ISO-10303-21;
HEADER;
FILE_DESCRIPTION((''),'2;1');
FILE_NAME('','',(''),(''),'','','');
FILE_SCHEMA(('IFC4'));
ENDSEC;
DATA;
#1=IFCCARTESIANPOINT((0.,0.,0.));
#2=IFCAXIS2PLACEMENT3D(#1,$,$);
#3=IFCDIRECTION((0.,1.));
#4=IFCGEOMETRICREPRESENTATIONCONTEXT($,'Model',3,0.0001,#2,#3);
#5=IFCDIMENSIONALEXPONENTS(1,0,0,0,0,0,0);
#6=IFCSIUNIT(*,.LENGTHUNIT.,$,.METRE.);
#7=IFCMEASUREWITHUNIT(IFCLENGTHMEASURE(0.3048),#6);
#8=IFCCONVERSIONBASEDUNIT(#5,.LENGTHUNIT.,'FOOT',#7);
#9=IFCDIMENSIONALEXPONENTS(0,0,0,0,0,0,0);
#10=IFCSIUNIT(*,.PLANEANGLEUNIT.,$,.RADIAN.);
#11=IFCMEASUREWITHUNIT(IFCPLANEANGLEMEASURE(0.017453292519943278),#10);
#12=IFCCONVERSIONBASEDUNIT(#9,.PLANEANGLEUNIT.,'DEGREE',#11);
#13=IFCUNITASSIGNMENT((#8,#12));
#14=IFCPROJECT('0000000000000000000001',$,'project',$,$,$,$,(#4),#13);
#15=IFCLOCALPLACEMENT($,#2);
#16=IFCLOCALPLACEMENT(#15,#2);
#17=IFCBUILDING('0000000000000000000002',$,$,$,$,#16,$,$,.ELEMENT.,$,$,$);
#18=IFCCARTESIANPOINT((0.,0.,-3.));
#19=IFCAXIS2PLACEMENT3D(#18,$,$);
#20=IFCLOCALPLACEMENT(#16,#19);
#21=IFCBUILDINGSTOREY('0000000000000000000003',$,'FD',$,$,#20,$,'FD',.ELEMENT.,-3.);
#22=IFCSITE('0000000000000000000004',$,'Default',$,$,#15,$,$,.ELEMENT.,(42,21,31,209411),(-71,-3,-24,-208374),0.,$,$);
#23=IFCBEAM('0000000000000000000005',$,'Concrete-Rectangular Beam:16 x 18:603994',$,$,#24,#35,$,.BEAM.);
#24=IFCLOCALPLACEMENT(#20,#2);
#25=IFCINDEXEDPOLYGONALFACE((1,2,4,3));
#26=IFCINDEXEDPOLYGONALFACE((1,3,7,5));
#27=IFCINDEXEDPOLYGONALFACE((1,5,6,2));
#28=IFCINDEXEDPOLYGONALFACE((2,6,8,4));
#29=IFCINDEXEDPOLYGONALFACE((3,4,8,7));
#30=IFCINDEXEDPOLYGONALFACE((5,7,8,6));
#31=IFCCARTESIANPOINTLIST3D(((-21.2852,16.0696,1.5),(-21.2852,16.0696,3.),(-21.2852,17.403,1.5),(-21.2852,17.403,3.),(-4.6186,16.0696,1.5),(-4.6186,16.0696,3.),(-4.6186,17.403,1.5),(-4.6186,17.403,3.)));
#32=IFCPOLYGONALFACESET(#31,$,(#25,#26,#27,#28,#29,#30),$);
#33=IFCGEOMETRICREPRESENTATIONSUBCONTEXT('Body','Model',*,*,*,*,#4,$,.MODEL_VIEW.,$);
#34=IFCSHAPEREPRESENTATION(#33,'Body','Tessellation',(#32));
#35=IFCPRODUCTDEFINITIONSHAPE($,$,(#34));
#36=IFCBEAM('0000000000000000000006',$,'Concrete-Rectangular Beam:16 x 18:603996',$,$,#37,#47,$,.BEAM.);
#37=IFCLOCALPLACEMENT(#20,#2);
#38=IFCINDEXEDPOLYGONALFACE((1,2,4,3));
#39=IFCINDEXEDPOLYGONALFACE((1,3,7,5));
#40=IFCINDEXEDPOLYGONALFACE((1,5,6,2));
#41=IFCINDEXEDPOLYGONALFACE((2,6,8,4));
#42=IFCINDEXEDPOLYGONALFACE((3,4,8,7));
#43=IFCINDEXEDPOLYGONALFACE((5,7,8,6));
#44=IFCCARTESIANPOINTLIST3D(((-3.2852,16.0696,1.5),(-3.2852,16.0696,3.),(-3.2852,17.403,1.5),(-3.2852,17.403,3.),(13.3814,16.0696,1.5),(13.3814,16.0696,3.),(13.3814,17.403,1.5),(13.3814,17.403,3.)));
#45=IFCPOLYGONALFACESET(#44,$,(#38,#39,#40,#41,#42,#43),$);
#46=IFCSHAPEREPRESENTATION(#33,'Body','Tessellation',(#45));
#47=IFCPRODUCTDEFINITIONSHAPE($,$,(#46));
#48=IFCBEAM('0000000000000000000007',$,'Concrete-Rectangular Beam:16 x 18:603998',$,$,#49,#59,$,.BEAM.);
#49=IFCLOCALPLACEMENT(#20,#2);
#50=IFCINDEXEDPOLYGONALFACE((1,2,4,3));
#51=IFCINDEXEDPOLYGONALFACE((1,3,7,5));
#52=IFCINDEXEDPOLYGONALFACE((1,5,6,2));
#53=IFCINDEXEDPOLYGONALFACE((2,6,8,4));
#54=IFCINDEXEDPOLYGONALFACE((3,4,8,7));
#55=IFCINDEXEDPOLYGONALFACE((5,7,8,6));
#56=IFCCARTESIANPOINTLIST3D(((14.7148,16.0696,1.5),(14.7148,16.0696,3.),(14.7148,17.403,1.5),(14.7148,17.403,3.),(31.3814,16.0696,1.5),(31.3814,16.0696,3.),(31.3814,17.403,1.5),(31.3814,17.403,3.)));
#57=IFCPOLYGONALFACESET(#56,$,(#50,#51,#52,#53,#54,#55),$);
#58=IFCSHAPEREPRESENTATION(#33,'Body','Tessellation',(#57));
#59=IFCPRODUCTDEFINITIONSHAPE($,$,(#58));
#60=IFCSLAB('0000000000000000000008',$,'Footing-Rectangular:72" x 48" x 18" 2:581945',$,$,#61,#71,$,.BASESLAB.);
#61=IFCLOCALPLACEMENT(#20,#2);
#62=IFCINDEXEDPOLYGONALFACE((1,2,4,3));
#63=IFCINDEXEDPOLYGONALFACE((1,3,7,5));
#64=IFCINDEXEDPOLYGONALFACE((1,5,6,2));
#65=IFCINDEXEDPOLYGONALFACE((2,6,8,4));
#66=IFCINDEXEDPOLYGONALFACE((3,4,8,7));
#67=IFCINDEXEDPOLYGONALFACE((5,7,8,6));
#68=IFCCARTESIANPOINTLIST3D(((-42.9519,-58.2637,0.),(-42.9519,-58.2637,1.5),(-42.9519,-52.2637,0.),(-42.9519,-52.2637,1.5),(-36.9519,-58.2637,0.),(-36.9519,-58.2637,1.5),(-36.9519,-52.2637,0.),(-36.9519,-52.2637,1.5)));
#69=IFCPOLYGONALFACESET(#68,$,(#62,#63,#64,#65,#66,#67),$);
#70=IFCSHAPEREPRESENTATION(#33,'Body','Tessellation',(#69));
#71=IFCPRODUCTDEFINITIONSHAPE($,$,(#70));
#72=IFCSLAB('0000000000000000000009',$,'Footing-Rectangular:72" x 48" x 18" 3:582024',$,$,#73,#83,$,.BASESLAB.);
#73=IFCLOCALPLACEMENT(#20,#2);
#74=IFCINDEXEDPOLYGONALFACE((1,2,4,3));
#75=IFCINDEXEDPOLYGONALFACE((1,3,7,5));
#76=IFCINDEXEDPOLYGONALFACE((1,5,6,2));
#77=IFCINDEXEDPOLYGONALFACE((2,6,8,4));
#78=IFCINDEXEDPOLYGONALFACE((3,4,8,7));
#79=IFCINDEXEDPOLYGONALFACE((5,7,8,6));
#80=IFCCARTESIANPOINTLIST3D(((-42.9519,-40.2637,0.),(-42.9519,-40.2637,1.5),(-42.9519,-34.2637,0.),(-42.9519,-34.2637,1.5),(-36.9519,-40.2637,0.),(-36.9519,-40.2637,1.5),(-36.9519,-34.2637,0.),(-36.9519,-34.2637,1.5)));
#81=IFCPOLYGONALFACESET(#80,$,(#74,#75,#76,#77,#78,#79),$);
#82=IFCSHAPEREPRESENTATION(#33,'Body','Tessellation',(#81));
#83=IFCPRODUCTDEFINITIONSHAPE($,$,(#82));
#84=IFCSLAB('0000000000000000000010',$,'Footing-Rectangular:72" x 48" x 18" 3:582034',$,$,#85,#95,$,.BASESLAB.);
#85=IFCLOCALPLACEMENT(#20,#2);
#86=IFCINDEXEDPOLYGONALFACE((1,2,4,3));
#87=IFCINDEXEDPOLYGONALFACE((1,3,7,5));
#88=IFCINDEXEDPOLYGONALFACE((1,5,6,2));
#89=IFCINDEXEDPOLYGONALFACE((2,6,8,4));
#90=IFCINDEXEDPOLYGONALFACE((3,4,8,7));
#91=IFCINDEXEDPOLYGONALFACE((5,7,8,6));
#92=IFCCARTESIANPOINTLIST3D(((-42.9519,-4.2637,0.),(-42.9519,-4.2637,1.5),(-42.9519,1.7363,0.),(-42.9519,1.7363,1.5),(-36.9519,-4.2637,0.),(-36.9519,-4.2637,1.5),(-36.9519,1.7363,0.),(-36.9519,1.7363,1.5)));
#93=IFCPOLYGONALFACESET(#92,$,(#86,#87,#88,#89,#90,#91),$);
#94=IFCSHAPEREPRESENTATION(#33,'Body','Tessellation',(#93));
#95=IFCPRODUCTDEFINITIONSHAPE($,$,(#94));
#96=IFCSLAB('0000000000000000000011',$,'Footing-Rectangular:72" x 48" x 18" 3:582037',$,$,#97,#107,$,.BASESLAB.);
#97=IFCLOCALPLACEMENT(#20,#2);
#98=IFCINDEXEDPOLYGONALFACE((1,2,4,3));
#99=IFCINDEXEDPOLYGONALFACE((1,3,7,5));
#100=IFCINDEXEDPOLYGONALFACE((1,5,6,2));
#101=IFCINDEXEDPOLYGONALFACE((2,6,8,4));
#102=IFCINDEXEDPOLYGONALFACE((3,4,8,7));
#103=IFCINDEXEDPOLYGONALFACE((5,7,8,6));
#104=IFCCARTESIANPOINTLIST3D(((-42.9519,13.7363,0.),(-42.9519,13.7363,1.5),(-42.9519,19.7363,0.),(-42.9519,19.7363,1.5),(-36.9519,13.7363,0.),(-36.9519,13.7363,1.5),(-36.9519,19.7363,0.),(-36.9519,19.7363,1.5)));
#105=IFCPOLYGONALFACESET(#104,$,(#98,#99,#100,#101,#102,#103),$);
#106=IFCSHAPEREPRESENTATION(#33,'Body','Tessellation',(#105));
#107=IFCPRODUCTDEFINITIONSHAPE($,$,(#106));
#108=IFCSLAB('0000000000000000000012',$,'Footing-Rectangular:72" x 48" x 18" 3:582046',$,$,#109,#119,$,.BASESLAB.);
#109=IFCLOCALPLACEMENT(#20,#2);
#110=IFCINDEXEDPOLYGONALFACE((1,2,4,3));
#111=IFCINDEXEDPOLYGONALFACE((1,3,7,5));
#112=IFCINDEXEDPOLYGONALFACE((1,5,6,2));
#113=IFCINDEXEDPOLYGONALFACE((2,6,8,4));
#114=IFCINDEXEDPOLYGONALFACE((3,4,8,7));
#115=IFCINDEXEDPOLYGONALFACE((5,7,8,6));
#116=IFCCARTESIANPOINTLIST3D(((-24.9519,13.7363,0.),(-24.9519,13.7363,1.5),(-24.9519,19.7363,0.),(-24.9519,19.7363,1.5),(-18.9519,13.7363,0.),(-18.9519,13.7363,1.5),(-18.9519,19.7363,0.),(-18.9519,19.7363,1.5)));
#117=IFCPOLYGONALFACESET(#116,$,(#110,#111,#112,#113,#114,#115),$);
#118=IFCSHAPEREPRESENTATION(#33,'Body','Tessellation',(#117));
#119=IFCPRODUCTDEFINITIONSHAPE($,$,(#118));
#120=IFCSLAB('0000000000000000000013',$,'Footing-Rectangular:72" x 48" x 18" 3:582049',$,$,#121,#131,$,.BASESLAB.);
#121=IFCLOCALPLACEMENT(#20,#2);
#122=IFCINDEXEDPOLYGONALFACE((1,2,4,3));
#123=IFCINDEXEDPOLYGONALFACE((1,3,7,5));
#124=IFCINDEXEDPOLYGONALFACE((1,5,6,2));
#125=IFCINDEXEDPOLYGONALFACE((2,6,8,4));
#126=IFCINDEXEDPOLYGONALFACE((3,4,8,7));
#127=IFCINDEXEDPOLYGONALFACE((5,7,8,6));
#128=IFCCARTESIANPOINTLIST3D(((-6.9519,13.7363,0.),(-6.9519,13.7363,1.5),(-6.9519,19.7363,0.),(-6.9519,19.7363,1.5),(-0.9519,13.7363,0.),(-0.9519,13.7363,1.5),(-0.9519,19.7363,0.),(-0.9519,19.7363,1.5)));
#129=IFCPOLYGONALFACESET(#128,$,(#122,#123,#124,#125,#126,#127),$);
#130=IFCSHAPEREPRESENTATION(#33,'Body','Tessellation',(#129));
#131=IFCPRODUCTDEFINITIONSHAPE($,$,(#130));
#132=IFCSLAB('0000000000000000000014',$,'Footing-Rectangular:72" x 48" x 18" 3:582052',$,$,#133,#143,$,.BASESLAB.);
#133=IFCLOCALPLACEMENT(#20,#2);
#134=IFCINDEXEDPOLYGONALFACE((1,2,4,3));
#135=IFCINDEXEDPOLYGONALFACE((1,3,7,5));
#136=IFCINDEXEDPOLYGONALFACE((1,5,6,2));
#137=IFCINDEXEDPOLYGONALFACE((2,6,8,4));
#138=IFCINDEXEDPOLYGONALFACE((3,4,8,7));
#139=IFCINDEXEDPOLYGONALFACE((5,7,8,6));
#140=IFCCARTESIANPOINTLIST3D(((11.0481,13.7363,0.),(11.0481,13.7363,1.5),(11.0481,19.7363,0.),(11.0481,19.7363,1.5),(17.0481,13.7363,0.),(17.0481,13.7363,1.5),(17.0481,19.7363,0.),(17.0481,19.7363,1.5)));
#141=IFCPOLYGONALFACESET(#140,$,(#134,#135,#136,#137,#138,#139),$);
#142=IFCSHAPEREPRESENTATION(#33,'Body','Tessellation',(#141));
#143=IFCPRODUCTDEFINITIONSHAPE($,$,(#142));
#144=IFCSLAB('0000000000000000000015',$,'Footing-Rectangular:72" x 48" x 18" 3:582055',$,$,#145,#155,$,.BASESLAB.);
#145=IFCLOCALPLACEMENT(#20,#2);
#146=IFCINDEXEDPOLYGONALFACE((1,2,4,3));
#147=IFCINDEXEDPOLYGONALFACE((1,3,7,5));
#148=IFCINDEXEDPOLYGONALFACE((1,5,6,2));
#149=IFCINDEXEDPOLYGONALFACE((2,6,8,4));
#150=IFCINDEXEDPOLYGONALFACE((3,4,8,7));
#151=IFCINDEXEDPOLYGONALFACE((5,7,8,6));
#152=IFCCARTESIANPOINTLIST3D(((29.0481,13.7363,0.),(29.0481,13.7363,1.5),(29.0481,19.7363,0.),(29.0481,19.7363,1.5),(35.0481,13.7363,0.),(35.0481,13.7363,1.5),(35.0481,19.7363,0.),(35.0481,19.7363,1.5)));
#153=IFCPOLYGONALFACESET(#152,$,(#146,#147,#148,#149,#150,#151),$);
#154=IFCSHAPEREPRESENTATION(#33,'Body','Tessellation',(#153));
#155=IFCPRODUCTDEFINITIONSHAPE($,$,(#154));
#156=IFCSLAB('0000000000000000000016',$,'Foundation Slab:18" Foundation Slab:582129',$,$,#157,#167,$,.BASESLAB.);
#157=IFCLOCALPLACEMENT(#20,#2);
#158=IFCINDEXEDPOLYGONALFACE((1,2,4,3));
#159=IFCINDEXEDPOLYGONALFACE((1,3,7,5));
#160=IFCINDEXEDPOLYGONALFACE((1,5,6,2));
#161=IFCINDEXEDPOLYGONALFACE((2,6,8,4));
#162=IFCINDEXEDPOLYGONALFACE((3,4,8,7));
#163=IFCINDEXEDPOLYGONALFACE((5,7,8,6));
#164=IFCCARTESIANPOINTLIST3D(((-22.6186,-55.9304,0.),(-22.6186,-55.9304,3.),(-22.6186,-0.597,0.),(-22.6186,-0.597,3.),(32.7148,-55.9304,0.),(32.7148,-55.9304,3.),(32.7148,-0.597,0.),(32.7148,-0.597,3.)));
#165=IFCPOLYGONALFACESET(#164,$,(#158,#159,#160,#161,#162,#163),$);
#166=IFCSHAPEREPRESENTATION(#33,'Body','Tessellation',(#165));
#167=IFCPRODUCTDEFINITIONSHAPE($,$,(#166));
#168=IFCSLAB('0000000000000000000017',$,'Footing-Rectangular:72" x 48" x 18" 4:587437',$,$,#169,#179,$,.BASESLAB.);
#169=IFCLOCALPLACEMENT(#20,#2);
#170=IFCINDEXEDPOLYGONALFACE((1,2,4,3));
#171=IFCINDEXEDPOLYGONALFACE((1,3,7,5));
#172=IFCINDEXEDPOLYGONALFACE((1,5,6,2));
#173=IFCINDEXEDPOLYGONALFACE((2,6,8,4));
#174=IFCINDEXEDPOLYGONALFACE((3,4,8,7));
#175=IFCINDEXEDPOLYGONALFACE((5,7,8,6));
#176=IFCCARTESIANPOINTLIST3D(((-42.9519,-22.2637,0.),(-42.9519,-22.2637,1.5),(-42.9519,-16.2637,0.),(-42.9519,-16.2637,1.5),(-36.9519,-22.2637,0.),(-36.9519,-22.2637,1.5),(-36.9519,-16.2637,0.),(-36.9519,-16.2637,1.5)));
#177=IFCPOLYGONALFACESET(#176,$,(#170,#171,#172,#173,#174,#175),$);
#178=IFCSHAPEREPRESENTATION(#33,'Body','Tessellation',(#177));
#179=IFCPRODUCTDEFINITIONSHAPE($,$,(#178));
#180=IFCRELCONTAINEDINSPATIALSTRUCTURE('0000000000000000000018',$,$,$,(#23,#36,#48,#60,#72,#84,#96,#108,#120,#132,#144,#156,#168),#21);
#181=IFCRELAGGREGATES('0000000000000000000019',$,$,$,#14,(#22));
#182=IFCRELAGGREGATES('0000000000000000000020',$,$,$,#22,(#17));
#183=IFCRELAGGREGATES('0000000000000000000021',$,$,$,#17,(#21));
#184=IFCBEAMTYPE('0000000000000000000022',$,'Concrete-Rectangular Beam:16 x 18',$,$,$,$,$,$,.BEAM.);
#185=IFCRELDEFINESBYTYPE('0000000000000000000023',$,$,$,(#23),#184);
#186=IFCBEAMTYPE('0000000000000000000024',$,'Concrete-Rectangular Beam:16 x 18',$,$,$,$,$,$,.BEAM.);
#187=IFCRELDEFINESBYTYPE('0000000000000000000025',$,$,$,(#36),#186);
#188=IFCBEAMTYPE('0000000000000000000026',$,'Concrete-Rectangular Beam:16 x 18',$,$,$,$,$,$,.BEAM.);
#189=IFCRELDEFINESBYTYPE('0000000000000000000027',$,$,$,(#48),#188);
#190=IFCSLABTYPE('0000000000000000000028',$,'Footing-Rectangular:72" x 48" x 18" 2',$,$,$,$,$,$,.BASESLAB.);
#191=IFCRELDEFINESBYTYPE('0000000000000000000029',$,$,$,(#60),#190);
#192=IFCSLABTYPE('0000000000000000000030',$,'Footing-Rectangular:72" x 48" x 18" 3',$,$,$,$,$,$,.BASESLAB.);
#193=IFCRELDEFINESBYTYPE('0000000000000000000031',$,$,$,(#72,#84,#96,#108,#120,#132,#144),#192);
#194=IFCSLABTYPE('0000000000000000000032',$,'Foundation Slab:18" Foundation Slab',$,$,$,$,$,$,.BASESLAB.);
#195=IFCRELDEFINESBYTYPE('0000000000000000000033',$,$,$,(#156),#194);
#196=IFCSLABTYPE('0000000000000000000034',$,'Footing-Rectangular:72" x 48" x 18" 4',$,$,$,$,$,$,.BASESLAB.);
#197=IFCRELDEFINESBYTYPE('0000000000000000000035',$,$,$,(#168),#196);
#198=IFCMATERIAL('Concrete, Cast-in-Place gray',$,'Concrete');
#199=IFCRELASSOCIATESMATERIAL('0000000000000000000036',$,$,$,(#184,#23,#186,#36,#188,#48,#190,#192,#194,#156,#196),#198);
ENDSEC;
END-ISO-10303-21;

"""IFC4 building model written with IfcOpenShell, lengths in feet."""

from ifc_helpers import new_model, entity, si_unit, converted_unit, direction, frame, origin, place, context, subcontext, project, spatial, indexed_curve, outline, extrude, source, transform, mapped, material, type_object, type_shapes, element, save


model = new_model("IFC4")

# Units and contexts
model_context = context("Model", 3, precision=0.0001, world=origin(), true_north=direction((0.0, 1.0)))
body_context = subcontext(model_context, "Body", "Model", "MODEL_VIEW")
ifc_project = project(units=[converted_unit("LENGTHUNIT", "FOOT", entity("IfcLengthMeasure", 0.3048), si_unit("LENGTHUNIT", "METRE"), dimensions=[1, 0, 0, 0, 0, 0, 0]), converted_unit("PLANEANGLEUNIT", "DEGREE", entity("IfcPlaneAngleMeasure", 0.017453292519943278), si_unit("PLANEANGLEUNIT", "RADIAN"), dimensions=[0, 0, 0, 0, 0, 0, 0])], contexts=[model_context])

# Site, building, storey
site_placement = place(None, origin())
site = spatial("IfcSite", under=ifc_project, at=site_placement, Name="Default", CompositionType="ELEMENT", RefLatitude=(42, 21, 31, 209411), RefLongitude=(-71, -3, -24, -208374), RefElevation=0.0)
building_placement = place(site_placement, origin())
building = spatial("IfcBuilding", under=site, at=building_placement, CompositionType="ELEMENT")
storey_placement = place(building_placement, frame((0.0, 0.0, -3.0)))
storey = spatial("IfcBuildingStorey", under=building, at=storey_placement, Name="FD", LongName="FD", CompositionType="ELEMENT", Elevation=-3.0)

# Shared definitions
ifc_material = material(Name="Concrete, Cast-in-Place gray", Category="Concrete")

# Beams
beam_type_1 = type_object("IfcBeamType", Name="Concrete-Rectangular Beam:16 x 18", PredefinedType="BEAM", material=ifc_material)
shared_shape_1 = source(origin(), body_context, "Body", "SweptSolid", [
    extrude(outline(indexed_curve([(-0.75, -0.6667), (0.75, -0.6667), (0.75, 0.6667), (-0.75, 0.6667), (-0.75, -0.6667)], self_intersect=False)), frame((-21.2852, 16.7363, -0.75), z_axis=(1.0, 0.0, 0.0), x_axis=(0.0, 0.0, -1.0)), (0.0, 0.0, 1.0), 16.6667),
])
type_shapes(beam_type_1, [shared_shape_1])
beam_1_placement = place(storey_placement, frame((0.0, 0.0, 3.0)))
element("IfcBeam", 1, at=beam_1_placement, inside=storey, type_object=beam_type_1, material=ifc_material, Name="Concrete-Rectangular Beam:16 x 18:603994", PredefinedType="BEAM", context=body_context, shape_type="MappedRepresentation", body=[
    mapped(shared_shape_1, transform((0.0, 0.0, 0.0), scale=1.0)),
])
beam_type_2 = type_object("IfcBeamType", Name="Concrete-Rectangular Beam:16 x 18", PredefinedType="BEAM", material=ifc_material)
shared_shape_2 = source(origin(), body_context, "Body", "SweptSolid", [
    extrude(outline(indexed_curve([(-0.75, -0.6667), (0.75, -0.6667), (0.75, 0.6667), (-0.75, 0.6667), (-0.75, -0.6667)], self_intersect=False)), frame((-3.2852, 16.7363, -0.75), z_axis=(1.0, 0.0, 0.0), x_axis=(0.0, 0.0, -1.0)), (0.0, 0.0, 1.0), 16.6667),
])
type_shapes(beam_type_2, [shared_shape_2])
beam_2_placement = place(storey_placement, frame((0.0, 0.0, 3.0)))
element("IfcBeam", 2, at=beam_2_placement, inside=storey, type_object=beam_type_2, material=ifc_material, Name="Concrete-Rectangular Beam:16 x 18:603996", PredefinedType="BEAM", context=body_context, shape_type="MappedRepresentation", body=[
    mapped(shared_shape_2, transform((0.0, 0.0, 0.0), scale=1.0)),
])
beam_type_3 = type_object("IfcBeamType", Name="Concrete-Rectangular Beam:16 x 18", PredefinedType="BEAM", material=ifc_material)
shared_shape_3 = source(origin(), body_context, "Body", "SweptSolid", [
    extrude(outline(indexed_curve([(-0.75, -0.6667), (0.75, -0.6667), (0.75, 0.6667), (-0.75, 0.6667), (-0.75, -0.6667)], self_intersect=False)), frame((14.7148, 16.7363, -0.75), z_axis=(1.0, 0.0, 0.0), x_axis=(0.0, 0.0, -1.0)), (0.0, 0.0, 1.0), 16.6667),
])
type_shapes(beam_type_3, [shared_shape_3])
beam_3_placement = place(storey_placement, frame((0.0, 0.0, 3.0)))
element("IfcBeam", 3, at=beam_3_placement, inside=storey, type_object=beam_type_3, material=ifc_material, Name="Concrete-Rectangular Beam:16 x 18:603998", PredefinedType="BEAM", context=body_context, shape_type="MappedRepresentation", body=[
    mapped(shared_shape_3, transform((0.0, 0.0, 0.0), scale=1.0)),
])

# Slabs
slab_type_1 = type_object("IfcSlabType", Name="Footing-Rectangular:72\" x 48\" x 18\" 2", PredefinedType="BASESLAB", material=ifc_material)
slab_1_placement = place(storey_placement, origin())
element("IfcSlab", 4, at=slab_1_placement, inside=storey, type_object=slab_type_1, Name="Footing-Rectangular:72\" x 48\" x 18\" 2:581945", PredefinedType="BASESLAB", context=body_context, shape_type="SweptSolid", body=[
    extrude(outline(indexed_curve([(-3.0, -3.0), (3.0, -3.0), (3.0, 3.0), (-3.0, 3.0), (-3.0, -3.0)], self_intersect=False)), frame((-39.9519, -55.2637, 0.0), z_axis=(0.0, 0.0, 1.0), x_axis=(-1.0, 0.0, 0.0)), (0.0, 0.0, 1.0), 1.5),
])
slab_type_2 = type_object("IfcSlabType", Name="Footing-Rectangular:72\" x 48\" x 18\" 3", PredefinedType="BASESLAB", material=ifc_material)
slab_2_placement = place(storey_placement, origin())
element("IfcSlab", 5, at=slab_2_placement, inside=storey, type_object=slab_type_2, Name="Footing-Rectangular:72\" x 48\" x 18\" 3:582024", PredefinedType="BASESLAB", context=body_context, shape_type="SweptSolid", body=[
    extrude(outline(indexed_curve([(-3.0, -3.0), (3.0, -3.0), (3.0, 3.0), (-3.0, 3.0), (-3.0, -3.0)], self_intersect=False)), frame((-39.9519, -37.2637, 0.0), z_axis=(0.0, 0.0, 1.0), x_axis=(-1.0, 0.0, 0.0)), (0.0, 0.0, 1.0), 1.5),
])
slab_3_placement = place(storey_placement, origin())
element("IfcSlab", 6, at=slab_3_placement, inside=storey, type_object=slab_type_2, Name="Footing-Rectangular:72\" x 48\" x 18\" 3:582034", PredefinedType="BASESLAB", context=body_context, shape_type="SweptSolid", body=[
    extrude(outline(indexed_curve([(-3.0, -3.0), (3.0, -3.0), (3.0, 3.0), (-3.0, 3.0), (-3.0, -3.0)], self_intersect=False)), frame((-39.9519, -1.2637, 0.0), z_axis=(0.0, 0.0, 1.0), x_axis=(-1.0, 0.0, 0.0)), (0.0, 0.0, 1.0), 1.5),
])
slab_4_placement = place(storey_placement, origin())
element("IfcSlab", 7, at=slab_4_placement, inside=storey, type_object=slab_type_2, Name="Footing-Rectangular:72\" x 48\" x 18\" 3:582037", PredefinedType="BASESLAB", context=body_context, shape_type="SweptSolid", body=[
    extrude(outline(indexed_curve([(-3.0, -3.0), (3.0, -3.0), (3.0, 3.0), (-3.0, 3.0), (-3.0, -3.0)], self_intersect=False)), frame((-39.9519, 16.7363, 0.0), z_axis=(0.0, 0.0, 1.0), x_axis=(-1.0, 0.0, 0.0)), (0.0, 0.0, 1.0), 1.5),
])
slab_5_placement = place(storey_placement, origin())
element("IfcSlab", 8, at=slab_5_placement, inside=storey, type_object=slab_type_2, Name="Footing-Rectangular:72\" x 48\" x 18\" 3:582046", PredefinedType="BASESLAB", context=body_context, shape_type="SweptSolid", body=[
    extrude(outline(indexed_curve([(-3.0, -3.0), (3.0, -3.0), (3.0, 3.0), (-3.0, 3.0), (-3.0, -3.0)], self_intersect=False)), frame((-21.9519, 16.7363, 0.0), z_axis=(0.0, 0.0, 1.0), x_axis=(-1.0, 0.0, 0.0)), (0.0, 0.0, 1.0), 1.5),
])
slab_6_placement = place(storey_placement, origin())
element("IfcSlab", 9, at=slab_6_placement, inside=storey, type_object=slab_type_2, Name="Footing-Rectangular:72\" x 48\" x 18\" 3:582049", PredefinedType="BASESLAB", context=body_context, shape_type="SweptSolid", body=[
    extrude(outline(indexed_curve([(-3.0, -3.0), (3.0, -3.0), (3.0, 3.0), (-3.0, 3.0), (-3.0, -3.0)], self_intersect=False)), frame((-3.9519, 16.7363, 0.0), z_axis=(0.0, 0.0, 1.0), x_axis=(-1.0, 0.0, 0.0)), (0.0, 0.0, 1.0), 1.5),
])
slab_7_placement = place(storey_placement, origin())
element("IfcSlab", 10, at=slab_7_placement, inside=storey, type_object=slab_type_2, Name="Footing-Rectangular:72\" x 48\" x 18\" 3:582052", PredefinedType="BASESLAB", context=body_context, shape_type="SweptSolid", body=[
    extrude(outline(indexed_curve([(-3.0, -3.0), (3.0, -3.0), (3.0, 3.0), (-3.0, 3.0), (-3.0, -3.0)], self_intersect=False)), frame((14.0481, 16.7363, 0.0), z_axis=(0.0, 0.0, 1.0), x_axis=(-1.0, 0.0, 0.0)), (0.0, 0.0, 1.0), 1.5),
])
slab_8_placement = place(storey_placement, origin())
element("IfcSlab", 11, at=slab_8_placement, inside=storey, type_object=slab_type_2, Name="Footing-Rectangular:72\" x 48\" x 18\" 3:582055", PredefinedType="BASESLAB", context=body_context, shape_type="SweptSolid", body=[
    extrude(outline(indexed_curve([(-3.0, -3.0), (3.0, -3.0), (3.0, 3.0), (-3.0, 3.0), (-3.0, -3.0)], self_intersect=False)), frame((32.0481, 16.7363, 0.0), z_axis=(0.0, 0.0, 1.0), x_axis=(-1.0, 0.0, 0.0)), (0.0, 0.0, 1.0), 1.5),
])
slab_type_3 = type_object("IfcSlabType", Name="Foundation Slab:18\" Foundation Slab", PredefinedType="BASESLAB", material=ifc_material)
slab_9_placement = place(storey_placement, origin())
element("IfcSlab", 12, at=slab_9_placement, inside=storey, type_object=slab_type_3, material=ifc_material, Name="Foundation Slab:18\" Foundation Slab:582129", PredefinedType="BASESLAB", context=body_context, shape_type="SweptSolid", body=[
    extrude(outline(indexed_curve([(-27.6667, -27.6667), (27.6667, -27.6667), (27.6667, 27.6667), (-27.6667, 27.6667), (-27.6667, -27.6667)], self_intersect=False)), frame((5.0481, -28.2637, 3.0), z_axis=(0.0, 0.0, -1.0), x_axis=(0.0, 1.0, 0.0)), (0.0, 0.0, 1.0), 3.0),
])
slab_type_4 = type_object("IfcSlabType", Name="Footing-Rectangular:72\" x 48\" x 18\" 4", PredefinedType="BASESLAB", material=ifc_material)
slab_10_placement = place(storey_placement, origin())
element("IfcSlab", 13, at=slab_10_placement, inside=storey, type_object=slab_type_4, Name="Footing-Rectangular:72\" x 48\" x 18\" 4:587437", PredefinedType="BASESLAB", context=body_context, shape_type="SweptSolid", body=[
    extrude(outline(indexed_curve([(-3.0, -3.0), (3.0, -3.0), (3.0, 3.0), (-3.0, 3.0), (-3.0, -3.0)], self_intersect=False)), frame((-39.9519, -19.2637, 0.0), z_axis=(0.0, 0.0, 1.0), x_axis=(-1.0, 0.0, 0.0)), (0.0, 0.0, 1.0), 1.5),
])

save(model, "model.ifc")
